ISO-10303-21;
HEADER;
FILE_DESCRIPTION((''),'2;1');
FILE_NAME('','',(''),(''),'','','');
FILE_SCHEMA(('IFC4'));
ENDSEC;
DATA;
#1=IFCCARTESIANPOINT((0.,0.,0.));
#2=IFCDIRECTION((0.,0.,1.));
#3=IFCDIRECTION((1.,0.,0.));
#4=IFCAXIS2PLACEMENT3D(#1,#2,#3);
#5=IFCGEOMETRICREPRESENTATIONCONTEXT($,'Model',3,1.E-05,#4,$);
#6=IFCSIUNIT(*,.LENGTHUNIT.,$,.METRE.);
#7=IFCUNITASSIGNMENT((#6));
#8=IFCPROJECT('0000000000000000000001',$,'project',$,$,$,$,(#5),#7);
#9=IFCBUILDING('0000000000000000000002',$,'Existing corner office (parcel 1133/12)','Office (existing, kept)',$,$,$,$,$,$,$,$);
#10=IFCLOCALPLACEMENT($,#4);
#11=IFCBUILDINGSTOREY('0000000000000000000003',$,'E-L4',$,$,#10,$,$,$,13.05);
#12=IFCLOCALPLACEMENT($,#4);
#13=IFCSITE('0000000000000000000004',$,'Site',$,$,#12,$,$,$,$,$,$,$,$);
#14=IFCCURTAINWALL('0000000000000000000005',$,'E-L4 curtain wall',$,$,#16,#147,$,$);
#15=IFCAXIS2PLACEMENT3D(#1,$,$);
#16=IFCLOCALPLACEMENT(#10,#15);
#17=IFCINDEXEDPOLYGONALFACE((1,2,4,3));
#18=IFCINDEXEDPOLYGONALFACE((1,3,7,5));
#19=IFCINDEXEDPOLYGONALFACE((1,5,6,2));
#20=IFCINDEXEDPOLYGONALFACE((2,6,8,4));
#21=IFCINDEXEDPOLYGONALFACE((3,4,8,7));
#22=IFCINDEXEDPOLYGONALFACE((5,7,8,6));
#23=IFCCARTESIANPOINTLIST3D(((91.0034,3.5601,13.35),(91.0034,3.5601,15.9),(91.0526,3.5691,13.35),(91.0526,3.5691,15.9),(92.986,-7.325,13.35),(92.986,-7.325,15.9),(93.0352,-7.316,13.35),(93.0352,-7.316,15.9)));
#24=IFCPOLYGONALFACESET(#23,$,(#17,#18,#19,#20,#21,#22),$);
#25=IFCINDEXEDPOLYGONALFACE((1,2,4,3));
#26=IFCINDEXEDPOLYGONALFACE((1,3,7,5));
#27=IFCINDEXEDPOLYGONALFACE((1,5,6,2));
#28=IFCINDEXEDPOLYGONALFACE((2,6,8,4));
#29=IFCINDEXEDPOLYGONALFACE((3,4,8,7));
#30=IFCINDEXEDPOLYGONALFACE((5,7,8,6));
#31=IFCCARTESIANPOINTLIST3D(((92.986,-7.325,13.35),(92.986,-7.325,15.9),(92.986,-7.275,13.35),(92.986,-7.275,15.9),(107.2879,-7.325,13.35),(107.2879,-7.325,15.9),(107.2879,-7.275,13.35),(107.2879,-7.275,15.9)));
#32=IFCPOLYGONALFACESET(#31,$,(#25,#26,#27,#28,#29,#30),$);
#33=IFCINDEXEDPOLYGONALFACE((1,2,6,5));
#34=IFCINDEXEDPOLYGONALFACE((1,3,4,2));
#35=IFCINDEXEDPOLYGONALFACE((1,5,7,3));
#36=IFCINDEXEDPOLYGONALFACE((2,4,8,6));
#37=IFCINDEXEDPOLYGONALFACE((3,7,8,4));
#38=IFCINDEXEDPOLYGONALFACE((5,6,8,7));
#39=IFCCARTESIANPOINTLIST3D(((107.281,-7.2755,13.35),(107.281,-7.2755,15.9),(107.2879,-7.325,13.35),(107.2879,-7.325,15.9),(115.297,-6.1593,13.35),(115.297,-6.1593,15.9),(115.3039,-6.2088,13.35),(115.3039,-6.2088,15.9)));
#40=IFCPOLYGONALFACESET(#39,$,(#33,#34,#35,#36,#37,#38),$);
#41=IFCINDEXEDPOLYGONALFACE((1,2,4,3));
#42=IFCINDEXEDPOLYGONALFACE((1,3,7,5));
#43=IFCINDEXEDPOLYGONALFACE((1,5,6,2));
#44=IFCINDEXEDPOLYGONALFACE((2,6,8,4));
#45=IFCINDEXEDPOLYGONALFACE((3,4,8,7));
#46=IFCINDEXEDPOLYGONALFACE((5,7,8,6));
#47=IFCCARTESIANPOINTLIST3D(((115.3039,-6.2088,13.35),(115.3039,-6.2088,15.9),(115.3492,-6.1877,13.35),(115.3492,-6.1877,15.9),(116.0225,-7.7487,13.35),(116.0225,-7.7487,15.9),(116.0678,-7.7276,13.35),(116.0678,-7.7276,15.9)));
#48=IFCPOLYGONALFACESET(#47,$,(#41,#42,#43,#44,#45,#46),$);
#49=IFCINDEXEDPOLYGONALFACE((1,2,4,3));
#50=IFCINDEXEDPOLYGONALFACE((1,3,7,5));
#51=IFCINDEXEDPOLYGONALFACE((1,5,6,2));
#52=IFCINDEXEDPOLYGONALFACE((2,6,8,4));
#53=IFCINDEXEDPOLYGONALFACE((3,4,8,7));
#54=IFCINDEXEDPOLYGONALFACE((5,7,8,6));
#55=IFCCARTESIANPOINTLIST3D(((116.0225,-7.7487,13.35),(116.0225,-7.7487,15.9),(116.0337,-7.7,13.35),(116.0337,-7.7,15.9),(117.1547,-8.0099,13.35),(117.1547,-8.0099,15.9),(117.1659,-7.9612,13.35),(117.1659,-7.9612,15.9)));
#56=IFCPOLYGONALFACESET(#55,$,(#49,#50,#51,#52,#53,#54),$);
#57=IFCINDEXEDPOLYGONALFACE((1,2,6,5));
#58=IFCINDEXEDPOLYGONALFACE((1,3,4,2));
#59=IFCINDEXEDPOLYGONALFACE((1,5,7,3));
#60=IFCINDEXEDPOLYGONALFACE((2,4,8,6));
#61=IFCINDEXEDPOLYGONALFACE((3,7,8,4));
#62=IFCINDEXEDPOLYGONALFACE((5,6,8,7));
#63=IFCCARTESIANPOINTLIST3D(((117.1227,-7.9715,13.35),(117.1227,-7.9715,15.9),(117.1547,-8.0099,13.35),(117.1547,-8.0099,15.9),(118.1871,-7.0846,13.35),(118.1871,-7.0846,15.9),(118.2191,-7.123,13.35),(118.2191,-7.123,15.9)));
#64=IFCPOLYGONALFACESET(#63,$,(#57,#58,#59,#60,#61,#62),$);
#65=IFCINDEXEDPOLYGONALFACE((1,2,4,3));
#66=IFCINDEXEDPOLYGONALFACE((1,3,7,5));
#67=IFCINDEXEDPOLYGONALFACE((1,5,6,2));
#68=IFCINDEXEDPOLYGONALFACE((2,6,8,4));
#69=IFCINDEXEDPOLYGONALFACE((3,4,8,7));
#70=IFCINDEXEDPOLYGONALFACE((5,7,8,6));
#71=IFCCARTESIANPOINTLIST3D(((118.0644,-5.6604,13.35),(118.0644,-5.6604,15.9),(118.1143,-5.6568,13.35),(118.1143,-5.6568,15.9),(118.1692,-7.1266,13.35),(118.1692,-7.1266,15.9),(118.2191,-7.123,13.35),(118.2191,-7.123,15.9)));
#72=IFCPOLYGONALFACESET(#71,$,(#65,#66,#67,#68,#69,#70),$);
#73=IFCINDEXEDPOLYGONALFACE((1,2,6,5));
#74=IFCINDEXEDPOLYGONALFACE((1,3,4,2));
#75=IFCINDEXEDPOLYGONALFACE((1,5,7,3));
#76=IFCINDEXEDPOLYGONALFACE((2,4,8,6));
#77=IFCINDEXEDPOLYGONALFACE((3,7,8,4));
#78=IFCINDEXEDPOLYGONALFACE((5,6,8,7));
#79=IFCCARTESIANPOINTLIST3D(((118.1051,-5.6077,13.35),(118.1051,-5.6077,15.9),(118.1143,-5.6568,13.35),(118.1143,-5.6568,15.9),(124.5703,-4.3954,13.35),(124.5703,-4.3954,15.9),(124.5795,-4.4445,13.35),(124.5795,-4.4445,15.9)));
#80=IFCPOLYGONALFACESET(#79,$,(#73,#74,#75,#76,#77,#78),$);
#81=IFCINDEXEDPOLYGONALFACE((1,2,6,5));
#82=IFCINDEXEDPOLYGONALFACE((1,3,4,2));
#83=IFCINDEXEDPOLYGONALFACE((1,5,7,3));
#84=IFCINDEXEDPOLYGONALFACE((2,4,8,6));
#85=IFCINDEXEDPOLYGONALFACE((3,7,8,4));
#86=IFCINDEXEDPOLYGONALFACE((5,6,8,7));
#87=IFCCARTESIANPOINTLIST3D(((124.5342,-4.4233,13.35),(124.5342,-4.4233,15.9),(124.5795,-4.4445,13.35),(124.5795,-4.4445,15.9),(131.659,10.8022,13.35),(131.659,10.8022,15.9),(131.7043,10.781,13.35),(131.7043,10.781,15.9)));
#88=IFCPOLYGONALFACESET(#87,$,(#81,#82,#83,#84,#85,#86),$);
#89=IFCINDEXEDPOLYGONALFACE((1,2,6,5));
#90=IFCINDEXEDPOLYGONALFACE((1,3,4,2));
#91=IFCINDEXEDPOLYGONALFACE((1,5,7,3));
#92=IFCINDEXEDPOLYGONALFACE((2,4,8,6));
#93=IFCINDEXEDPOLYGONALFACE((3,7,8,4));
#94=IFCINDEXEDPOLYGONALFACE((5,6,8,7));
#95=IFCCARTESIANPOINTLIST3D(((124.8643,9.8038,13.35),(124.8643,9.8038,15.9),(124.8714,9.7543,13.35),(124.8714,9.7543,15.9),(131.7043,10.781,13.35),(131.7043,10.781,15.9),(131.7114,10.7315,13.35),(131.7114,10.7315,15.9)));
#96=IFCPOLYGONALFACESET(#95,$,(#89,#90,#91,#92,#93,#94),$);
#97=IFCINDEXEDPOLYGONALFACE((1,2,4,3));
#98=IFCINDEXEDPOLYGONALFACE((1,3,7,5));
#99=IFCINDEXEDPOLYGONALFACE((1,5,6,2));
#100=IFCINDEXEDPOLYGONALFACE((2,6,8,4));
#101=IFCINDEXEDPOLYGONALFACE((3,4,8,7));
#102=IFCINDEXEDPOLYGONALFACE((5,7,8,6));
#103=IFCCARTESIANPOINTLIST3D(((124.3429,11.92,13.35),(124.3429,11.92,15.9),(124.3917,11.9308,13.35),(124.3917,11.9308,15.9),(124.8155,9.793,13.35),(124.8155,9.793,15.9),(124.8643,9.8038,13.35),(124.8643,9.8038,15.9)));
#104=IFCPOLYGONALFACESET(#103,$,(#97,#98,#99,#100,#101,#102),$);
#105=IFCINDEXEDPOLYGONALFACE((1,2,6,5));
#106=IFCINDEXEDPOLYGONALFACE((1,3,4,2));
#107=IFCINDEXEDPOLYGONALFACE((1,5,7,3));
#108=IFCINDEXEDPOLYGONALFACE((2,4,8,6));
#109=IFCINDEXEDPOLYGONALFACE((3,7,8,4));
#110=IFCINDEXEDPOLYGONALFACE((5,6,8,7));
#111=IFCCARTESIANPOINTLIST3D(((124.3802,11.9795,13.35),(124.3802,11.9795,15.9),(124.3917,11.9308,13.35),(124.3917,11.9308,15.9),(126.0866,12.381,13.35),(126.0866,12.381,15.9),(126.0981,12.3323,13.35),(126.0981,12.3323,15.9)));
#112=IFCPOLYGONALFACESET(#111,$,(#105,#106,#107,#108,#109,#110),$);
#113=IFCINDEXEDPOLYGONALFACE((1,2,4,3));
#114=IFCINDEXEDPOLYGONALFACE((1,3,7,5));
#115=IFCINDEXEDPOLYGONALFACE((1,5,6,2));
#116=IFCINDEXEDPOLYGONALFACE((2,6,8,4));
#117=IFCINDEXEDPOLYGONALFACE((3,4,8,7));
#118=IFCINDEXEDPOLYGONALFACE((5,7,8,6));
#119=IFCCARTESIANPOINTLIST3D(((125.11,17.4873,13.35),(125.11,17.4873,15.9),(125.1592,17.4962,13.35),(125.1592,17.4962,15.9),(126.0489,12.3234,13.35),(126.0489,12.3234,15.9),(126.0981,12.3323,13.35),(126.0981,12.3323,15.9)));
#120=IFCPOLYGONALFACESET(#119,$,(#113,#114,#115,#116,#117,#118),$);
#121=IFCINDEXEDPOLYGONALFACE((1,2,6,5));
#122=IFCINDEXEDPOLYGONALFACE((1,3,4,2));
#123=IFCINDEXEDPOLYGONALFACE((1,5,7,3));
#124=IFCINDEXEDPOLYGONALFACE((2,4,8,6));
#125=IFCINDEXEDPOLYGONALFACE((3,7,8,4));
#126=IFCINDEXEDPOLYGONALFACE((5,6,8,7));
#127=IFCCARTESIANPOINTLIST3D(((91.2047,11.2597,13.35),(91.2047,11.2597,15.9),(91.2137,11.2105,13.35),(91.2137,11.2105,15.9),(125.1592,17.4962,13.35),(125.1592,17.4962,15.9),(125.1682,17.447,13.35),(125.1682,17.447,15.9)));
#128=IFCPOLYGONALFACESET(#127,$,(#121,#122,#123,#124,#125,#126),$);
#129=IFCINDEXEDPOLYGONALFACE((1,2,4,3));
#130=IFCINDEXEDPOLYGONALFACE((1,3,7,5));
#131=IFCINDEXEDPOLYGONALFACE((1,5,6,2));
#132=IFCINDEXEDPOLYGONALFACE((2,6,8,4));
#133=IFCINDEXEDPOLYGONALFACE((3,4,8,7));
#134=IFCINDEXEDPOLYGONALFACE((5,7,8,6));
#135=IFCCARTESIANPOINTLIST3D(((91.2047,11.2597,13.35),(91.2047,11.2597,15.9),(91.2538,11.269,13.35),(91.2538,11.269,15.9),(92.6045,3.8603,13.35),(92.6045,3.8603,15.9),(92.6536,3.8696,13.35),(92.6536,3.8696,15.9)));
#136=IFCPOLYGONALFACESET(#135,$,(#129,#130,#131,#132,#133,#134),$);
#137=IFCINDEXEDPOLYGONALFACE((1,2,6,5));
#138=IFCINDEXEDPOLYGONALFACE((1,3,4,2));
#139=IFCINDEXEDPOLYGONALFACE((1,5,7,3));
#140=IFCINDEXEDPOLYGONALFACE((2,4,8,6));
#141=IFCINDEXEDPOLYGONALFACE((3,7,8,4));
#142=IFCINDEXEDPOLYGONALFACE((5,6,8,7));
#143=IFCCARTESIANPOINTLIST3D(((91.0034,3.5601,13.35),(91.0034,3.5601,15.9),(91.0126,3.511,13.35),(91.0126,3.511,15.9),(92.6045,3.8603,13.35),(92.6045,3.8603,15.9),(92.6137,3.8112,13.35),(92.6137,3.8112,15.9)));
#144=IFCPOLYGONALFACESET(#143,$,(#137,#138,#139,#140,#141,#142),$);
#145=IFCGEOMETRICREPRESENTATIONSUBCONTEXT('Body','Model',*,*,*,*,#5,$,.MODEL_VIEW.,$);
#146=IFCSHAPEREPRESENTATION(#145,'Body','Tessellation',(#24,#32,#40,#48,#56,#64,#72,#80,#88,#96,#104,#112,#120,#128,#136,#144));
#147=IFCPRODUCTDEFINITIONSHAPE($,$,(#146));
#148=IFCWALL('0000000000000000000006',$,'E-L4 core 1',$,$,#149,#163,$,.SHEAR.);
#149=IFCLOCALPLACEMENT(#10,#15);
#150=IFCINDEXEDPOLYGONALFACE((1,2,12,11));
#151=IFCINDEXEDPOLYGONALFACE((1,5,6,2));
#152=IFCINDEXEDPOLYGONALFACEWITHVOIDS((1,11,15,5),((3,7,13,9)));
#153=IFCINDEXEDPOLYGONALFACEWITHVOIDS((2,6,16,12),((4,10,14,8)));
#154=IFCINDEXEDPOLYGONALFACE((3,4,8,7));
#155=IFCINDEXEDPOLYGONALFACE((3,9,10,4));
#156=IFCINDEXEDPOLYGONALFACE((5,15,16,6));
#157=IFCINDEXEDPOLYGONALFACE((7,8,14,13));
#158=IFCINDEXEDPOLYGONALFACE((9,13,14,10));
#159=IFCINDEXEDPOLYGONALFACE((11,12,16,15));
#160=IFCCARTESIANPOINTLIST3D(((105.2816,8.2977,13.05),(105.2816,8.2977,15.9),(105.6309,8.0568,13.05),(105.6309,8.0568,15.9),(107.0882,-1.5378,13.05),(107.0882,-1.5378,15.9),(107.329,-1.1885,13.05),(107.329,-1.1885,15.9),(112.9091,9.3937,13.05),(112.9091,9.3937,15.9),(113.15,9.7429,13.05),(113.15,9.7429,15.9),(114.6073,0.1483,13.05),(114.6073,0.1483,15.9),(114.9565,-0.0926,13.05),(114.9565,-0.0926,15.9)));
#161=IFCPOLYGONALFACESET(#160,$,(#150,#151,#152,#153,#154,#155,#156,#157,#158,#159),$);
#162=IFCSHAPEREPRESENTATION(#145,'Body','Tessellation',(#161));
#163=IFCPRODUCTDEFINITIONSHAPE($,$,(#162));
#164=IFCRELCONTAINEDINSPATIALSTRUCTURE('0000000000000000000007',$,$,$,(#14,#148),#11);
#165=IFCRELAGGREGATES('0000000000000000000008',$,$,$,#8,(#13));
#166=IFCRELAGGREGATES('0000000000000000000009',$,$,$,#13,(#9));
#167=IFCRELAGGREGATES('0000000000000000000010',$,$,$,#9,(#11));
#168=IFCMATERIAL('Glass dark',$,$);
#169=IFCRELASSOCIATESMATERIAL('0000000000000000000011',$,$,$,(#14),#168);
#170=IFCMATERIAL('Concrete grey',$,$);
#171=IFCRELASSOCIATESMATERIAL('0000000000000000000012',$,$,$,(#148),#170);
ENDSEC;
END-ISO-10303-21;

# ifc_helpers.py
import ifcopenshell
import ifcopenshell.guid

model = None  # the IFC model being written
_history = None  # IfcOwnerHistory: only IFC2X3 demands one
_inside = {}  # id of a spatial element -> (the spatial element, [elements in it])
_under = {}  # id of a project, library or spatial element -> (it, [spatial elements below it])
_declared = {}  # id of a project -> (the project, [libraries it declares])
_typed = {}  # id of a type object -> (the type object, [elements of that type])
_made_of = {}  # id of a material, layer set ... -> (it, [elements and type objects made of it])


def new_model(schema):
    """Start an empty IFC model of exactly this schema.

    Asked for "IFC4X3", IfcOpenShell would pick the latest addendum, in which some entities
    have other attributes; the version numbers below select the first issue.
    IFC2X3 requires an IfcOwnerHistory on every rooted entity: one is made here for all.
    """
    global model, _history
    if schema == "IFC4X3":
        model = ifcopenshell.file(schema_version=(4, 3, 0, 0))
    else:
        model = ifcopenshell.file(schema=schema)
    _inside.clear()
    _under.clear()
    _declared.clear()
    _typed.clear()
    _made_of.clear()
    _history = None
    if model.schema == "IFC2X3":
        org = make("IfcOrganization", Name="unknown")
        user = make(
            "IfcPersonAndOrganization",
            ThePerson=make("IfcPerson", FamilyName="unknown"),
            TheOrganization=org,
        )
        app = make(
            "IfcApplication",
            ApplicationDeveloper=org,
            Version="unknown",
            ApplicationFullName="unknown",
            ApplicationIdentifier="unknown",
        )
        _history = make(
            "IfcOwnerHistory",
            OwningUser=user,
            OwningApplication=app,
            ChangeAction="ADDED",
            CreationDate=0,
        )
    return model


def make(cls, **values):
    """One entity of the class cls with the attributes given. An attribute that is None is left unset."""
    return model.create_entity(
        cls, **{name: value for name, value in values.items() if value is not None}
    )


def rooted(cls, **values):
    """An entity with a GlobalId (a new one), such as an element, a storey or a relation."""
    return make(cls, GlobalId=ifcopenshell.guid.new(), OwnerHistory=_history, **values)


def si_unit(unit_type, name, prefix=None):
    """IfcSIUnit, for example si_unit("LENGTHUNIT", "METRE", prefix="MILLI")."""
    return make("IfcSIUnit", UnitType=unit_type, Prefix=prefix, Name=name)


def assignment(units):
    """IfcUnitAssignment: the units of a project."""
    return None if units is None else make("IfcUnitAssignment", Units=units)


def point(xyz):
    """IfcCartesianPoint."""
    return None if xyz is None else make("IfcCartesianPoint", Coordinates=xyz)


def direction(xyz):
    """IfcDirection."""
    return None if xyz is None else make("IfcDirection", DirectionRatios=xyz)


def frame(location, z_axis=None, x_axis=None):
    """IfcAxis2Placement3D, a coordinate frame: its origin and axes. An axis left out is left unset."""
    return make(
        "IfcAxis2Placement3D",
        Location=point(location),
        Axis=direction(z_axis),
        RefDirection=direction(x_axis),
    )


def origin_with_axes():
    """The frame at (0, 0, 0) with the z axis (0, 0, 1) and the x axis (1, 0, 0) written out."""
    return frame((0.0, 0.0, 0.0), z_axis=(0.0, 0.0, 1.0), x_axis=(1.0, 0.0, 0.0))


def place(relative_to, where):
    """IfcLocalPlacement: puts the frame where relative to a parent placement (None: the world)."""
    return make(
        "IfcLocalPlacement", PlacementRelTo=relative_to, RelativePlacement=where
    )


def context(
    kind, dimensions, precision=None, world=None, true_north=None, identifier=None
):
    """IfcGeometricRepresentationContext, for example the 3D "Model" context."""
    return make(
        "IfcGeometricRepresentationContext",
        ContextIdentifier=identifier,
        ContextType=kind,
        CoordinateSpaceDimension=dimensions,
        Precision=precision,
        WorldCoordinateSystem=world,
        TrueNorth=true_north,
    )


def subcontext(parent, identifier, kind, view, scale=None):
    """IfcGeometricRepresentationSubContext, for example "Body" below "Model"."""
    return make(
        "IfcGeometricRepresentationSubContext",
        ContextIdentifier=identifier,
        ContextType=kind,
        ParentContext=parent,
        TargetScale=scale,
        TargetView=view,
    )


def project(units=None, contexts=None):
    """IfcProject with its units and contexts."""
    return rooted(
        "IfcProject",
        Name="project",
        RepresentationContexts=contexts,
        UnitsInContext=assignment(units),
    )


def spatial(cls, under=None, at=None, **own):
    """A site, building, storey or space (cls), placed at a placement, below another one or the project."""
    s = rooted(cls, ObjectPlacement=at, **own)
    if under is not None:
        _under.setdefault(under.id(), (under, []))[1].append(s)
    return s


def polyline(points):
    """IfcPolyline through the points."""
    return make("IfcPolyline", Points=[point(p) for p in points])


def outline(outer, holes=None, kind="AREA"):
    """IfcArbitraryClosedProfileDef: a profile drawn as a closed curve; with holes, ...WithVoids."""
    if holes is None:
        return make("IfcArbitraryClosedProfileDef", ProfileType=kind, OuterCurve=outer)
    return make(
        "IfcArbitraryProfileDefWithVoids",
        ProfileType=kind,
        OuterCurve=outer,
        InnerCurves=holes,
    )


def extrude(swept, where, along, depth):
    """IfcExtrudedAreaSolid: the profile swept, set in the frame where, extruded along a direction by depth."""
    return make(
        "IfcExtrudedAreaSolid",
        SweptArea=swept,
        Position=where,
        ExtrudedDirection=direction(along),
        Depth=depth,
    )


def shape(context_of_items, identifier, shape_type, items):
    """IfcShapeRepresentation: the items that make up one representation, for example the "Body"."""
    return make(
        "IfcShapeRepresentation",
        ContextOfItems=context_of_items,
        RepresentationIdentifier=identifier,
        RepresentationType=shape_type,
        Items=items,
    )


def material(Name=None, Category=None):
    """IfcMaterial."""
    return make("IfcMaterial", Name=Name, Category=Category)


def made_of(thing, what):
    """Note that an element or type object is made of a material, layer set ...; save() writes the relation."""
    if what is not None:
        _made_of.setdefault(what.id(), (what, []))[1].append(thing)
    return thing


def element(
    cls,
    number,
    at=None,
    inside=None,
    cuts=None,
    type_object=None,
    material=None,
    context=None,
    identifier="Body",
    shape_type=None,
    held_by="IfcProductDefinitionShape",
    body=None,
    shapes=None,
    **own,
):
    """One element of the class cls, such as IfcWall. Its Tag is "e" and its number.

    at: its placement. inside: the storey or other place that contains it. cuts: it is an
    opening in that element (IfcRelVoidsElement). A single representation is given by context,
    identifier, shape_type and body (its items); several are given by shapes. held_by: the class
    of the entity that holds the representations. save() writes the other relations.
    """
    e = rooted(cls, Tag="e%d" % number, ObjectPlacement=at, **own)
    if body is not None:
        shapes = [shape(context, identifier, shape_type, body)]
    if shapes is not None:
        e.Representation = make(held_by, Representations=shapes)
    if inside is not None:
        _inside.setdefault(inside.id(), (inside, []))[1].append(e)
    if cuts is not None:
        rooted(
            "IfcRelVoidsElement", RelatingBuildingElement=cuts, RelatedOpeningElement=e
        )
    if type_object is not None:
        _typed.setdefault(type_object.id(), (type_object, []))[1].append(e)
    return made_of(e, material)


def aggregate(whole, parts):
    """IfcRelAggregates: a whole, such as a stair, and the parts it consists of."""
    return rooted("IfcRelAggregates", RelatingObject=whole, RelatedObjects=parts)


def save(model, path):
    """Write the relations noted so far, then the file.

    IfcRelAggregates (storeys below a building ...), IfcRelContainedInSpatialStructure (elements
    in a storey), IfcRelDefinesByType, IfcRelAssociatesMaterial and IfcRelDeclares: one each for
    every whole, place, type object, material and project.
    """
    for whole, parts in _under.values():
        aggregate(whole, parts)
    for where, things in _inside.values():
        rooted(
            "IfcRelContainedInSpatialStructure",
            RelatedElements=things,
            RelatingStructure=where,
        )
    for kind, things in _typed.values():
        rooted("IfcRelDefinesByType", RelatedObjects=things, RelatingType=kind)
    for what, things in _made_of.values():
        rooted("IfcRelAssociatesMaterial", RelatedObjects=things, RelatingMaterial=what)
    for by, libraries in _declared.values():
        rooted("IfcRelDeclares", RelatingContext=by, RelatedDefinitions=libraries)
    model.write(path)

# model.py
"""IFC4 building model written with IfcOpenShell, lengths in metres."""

from ifc_helpers import new_model, si_unit, frame, origin_with_axes, place, context, subcontext, project, spatial, polyline, outline, extrude, material, element, save


model = new_model("IFC4")

# Units and contexts
model_context = context("Model", 3, precision=1e-05, world=origin_with_axes())
body_context = subcontext(model_context, "Body", "Model", "MODEL_VIEW")
ifc_project = project(units=[si_unit("LENGTHUNIT", "METRE")], contexts=[model_context])

# Site, building, storey
site_placement = place(None, origin_with_axes())
site = spatial("IfcSite", under=ifc_project, at=site_placement, Name="Site")
building = spatial("IfcBuilding", under=site, Name="Existing corner office (parcel 1133/12)", Description="Office (existing, kept)")
storey_placement = place(None, origin_with_axes())
storey = spatial("IfcBuildingStorey", under=building, at=storey_placement, Name="E-L4", Elevation=13.05)

# Shared definitions
ifc_material_1 = material(Name="Concrete grey")

# Curtain wall
ifc_material_2 = material(Name="Glass dark")
curtain_wall_placement = place(storey_placement, origin_with_axes())
element("IfcCurtainWall", 1, at=curtain_wall_placement, inside=storey, material=ifc_material_2, Name="E-L4 curtain wall", context=body_context, shape_type="SweptSolid", body=[
    extrude(outline(polyline([(91.0034, 3.5601), (92.986, -7.325), (93.0352, -7.316), (91.0526, 3.5691), (91.0034, 3.5601)])), frame((0.0, 0.0, 13.35), z_axis=(0.0, 0.0, 1.0), x_axis=(1.0, 0.0, 0.0)), (0.0, 0.0, 1.0), 2.55),
    extrude(outline(polyline([(92.986, -7.325), (107.2879, -7.325), (107.2879, -7.275), (92.986, -7.275), (92.986, -7.325)])), frame((0.0, 0.0, 13.35), z_axis=(0.0, 0.0, 1.0), x_axis=(1.0, 0.0, 0.0)), (0.0, 0.0, 1.0), 2.55),
    extrude(outline(polyline([(107.2879, -7.325), (115.3039, -6.2088), (115.297, -6.1593), (107.281, -7.2755), (107.2879, -7.325)])), frame((0.0, 0.0, 13.35), z_axis=(0.0, 0.0, 1.0), x_axis=(1.0, 0.0, 0.0)), (0.0, 0.0, 1.0), 2.55),
    extrude(outline(polyline([(115.3039, -6.2088), (116.0225, -7.7487), (116.0678, -7.7276), (115.3492, -6.1877), (115.3039, -6.2088)])), frame((0.0, 0.0, 13.35), z_axis=(0.0, 0.0, 1.0), x_axis=(1.0, 0.0, 0.0)), (0.0, 0.0, 1.0), 2.55),
    extrude(outline(polyline([(116.0225, -7.7487), (117.1547, -8.0099), (117.1659, -7.9612), (116.0337, -7.7), (116.0225, -7.7487)])), frame((0.0, 0.0, 13.35), z_axis=(0.0, 0.0, 1.0), x_axis=(1.0, 0.0, 0.0)), (0.0, 0.0, 1.0), 2.55),
    extrude(outline(polyline([(117.1547, -8.0099), (118.2191, -7.123), (118.1871, -7.0846), (117.1227, -7.9715), (117.1547, -8.0099)])), frame((0.0, 0.0, 13.35), z_axis=(0.0, 0.0, 1.0), x_axis=(1.0, 0.0, 0.0)), (0.0, 0.0, 1.0), 2.55),
    extrude(outline(polyline([(118.2191, -7.123), (118.1143, -5.6568), (118.0644, -5.6604), (118.1692, -7.1266), (118.2191, -7.123)])), frame((0.0, 0.0, 13.35), z_axis=(0.0, 0.0, 1.0), x_axis=(1.0, 0.0, 0.0)), (0.0, 0.0, 1.0), 2.55),
    extrude(outline(polyline([(118.1143, -5.6568), (124.5795, -4.4445), (124.5703, -4.3954), (118.1051, -5.6077), (118.1143, -5.6568)])), frame((0.0, 0.0, 13.35), z_axis=(0.0, 0.0, 1.0), x_axis=(1.0, 0.0, 0.0)), (0.0, 0.0, 1.0), 2.55),
    extrude(outline(polyline([(124.5795, -4.4445), (131.7043, 10.781), (131.659, 10.8022), (124.5342, -4.4233), (124.5795, -4.4445)])), frame((0.0, 0.0, 13.35), z_axis=(0.0, 0.0, 1.0), x_axis=(1.0, 0.0, 0.0)), (0.0, 0.0, 1.0), 2.55),
    extrude(outline(polyline([(131.7043, 10.781), (124.8643, 9.8038), (124.8714, 9.7543), (131.7114, 10.7315), (131.7043, 10.781)])), frame((0.0, 0.0, 13.35), z_axis=(0.0, 0.0, 1.0), x_axis=(1.0, 0.0, 0.0)), (0.0, 0.0, 1.0), 2.55),
    extrude(outline(polyline([(124.8643, 9.8038), (124.3917, 11.9308), (124.3429, 11.92), (124.8155, 9.793), (124.8643, 9.8038)])), frame((0.0, 0.0, 13.35), z_axis=(0.0, 0.0, 1.0), x_axis=(1.0, 0.0, 0.0)), (0.0, 0.0, 1.0), 2.55),
    extrude(outline(polyline([(124.3917, 11.9308), (126.0981, 12.3323), (126.0866, 12.381), (124.3802, 11.9795), (124.3917, 11.9308)])), frame((0.0, 0.0, 13.35), z_axis=(0.0, 0.0, 1.0), x_axis=(1.0, 0.0, 0.0)), (0.0, 0.0, 1.0), 2.55),
    extrude(outline(polyline([(126.0981, 12.3323), (125.1592, 17.4962), (125.11, 17.4873), (126.0489, 12.3234), (126.0981, 12.3323)])), frame((0.0, 0.0, 13.35), z_axis=(0.0, 0.0, 1.0), x_axis=(1.0, 0.0, 0.0)), (0.0, 0.0, 1.0), 2.55),
    extrude(outline(polyline([(125.1592, 17.4962), (91.2047, 11.2597), (91.2137, 11.2105), (125.1682, 17.447), (125.1592, 17.4962)])), frame((0.0, 0.0, 13.35), z_axis=(0.0, 0.0, 1.0), x_axis=(1.0, 0.0, 0.0)), (0.0, 0.0, 1.0), 2.55),
    extrude(outline(polyline([(91.2047, 11.2597), (92.6045, 3.8603), (92.6536, 3.8696), (91.2538, 11.269), (91.2047, 11.2597)])), frame((0.0, 0.0, 13.35), z_axis=(0.0, 0.0, 1.0), x_axis=(1.0, 0.0, 0.0)), (0.0, 0.0, 1.0), 2.55),
    extrude(outline(polyline([(92.6045, 3.8603), (91.0034, 3.5601), (91.0126, 3.511), (92.6137, 3.8112), (92.6045, 3.8603)])), frame((0.0, 0.0, 13.35), z_axis=(0.0, 0.0, 1.0), x_axis=(1.0, 0.0, 0.0)), (0.0, 0.0, 1.0), 2.55),
])

# Wall
wall_placement = place(storey_placement, origin_with_axes())
element("IfcWall", 2, at=wall_placement, inside=storey, material=ifc_material_1, Name="E-L4 core 1", PredefinedType="SHEAR", context=body_context, shape_type="SweptSolid", body=[
    extrude(outline(polyline([(113.15, 9.7429), (105.2816, 8.2977), (107.0882, -1.5378), (114.9565, -0.0926), (113.15, 9.7429)]), holes=[polyline([(112.9091, 9.3937), (105.6309, 8.0568), (107.329, -1.1885), (114.6073, 0.1483), (112.9091, 9.3937)])]), frame((0.0, 0.0, 13.05), z_axis=(0.0, 0.0, 1.0), x_axis=(1.0, 0.0, 0.0)), (0.0, 0.0, 1.0), 2.85),
])

save(model, "model.ifc")
